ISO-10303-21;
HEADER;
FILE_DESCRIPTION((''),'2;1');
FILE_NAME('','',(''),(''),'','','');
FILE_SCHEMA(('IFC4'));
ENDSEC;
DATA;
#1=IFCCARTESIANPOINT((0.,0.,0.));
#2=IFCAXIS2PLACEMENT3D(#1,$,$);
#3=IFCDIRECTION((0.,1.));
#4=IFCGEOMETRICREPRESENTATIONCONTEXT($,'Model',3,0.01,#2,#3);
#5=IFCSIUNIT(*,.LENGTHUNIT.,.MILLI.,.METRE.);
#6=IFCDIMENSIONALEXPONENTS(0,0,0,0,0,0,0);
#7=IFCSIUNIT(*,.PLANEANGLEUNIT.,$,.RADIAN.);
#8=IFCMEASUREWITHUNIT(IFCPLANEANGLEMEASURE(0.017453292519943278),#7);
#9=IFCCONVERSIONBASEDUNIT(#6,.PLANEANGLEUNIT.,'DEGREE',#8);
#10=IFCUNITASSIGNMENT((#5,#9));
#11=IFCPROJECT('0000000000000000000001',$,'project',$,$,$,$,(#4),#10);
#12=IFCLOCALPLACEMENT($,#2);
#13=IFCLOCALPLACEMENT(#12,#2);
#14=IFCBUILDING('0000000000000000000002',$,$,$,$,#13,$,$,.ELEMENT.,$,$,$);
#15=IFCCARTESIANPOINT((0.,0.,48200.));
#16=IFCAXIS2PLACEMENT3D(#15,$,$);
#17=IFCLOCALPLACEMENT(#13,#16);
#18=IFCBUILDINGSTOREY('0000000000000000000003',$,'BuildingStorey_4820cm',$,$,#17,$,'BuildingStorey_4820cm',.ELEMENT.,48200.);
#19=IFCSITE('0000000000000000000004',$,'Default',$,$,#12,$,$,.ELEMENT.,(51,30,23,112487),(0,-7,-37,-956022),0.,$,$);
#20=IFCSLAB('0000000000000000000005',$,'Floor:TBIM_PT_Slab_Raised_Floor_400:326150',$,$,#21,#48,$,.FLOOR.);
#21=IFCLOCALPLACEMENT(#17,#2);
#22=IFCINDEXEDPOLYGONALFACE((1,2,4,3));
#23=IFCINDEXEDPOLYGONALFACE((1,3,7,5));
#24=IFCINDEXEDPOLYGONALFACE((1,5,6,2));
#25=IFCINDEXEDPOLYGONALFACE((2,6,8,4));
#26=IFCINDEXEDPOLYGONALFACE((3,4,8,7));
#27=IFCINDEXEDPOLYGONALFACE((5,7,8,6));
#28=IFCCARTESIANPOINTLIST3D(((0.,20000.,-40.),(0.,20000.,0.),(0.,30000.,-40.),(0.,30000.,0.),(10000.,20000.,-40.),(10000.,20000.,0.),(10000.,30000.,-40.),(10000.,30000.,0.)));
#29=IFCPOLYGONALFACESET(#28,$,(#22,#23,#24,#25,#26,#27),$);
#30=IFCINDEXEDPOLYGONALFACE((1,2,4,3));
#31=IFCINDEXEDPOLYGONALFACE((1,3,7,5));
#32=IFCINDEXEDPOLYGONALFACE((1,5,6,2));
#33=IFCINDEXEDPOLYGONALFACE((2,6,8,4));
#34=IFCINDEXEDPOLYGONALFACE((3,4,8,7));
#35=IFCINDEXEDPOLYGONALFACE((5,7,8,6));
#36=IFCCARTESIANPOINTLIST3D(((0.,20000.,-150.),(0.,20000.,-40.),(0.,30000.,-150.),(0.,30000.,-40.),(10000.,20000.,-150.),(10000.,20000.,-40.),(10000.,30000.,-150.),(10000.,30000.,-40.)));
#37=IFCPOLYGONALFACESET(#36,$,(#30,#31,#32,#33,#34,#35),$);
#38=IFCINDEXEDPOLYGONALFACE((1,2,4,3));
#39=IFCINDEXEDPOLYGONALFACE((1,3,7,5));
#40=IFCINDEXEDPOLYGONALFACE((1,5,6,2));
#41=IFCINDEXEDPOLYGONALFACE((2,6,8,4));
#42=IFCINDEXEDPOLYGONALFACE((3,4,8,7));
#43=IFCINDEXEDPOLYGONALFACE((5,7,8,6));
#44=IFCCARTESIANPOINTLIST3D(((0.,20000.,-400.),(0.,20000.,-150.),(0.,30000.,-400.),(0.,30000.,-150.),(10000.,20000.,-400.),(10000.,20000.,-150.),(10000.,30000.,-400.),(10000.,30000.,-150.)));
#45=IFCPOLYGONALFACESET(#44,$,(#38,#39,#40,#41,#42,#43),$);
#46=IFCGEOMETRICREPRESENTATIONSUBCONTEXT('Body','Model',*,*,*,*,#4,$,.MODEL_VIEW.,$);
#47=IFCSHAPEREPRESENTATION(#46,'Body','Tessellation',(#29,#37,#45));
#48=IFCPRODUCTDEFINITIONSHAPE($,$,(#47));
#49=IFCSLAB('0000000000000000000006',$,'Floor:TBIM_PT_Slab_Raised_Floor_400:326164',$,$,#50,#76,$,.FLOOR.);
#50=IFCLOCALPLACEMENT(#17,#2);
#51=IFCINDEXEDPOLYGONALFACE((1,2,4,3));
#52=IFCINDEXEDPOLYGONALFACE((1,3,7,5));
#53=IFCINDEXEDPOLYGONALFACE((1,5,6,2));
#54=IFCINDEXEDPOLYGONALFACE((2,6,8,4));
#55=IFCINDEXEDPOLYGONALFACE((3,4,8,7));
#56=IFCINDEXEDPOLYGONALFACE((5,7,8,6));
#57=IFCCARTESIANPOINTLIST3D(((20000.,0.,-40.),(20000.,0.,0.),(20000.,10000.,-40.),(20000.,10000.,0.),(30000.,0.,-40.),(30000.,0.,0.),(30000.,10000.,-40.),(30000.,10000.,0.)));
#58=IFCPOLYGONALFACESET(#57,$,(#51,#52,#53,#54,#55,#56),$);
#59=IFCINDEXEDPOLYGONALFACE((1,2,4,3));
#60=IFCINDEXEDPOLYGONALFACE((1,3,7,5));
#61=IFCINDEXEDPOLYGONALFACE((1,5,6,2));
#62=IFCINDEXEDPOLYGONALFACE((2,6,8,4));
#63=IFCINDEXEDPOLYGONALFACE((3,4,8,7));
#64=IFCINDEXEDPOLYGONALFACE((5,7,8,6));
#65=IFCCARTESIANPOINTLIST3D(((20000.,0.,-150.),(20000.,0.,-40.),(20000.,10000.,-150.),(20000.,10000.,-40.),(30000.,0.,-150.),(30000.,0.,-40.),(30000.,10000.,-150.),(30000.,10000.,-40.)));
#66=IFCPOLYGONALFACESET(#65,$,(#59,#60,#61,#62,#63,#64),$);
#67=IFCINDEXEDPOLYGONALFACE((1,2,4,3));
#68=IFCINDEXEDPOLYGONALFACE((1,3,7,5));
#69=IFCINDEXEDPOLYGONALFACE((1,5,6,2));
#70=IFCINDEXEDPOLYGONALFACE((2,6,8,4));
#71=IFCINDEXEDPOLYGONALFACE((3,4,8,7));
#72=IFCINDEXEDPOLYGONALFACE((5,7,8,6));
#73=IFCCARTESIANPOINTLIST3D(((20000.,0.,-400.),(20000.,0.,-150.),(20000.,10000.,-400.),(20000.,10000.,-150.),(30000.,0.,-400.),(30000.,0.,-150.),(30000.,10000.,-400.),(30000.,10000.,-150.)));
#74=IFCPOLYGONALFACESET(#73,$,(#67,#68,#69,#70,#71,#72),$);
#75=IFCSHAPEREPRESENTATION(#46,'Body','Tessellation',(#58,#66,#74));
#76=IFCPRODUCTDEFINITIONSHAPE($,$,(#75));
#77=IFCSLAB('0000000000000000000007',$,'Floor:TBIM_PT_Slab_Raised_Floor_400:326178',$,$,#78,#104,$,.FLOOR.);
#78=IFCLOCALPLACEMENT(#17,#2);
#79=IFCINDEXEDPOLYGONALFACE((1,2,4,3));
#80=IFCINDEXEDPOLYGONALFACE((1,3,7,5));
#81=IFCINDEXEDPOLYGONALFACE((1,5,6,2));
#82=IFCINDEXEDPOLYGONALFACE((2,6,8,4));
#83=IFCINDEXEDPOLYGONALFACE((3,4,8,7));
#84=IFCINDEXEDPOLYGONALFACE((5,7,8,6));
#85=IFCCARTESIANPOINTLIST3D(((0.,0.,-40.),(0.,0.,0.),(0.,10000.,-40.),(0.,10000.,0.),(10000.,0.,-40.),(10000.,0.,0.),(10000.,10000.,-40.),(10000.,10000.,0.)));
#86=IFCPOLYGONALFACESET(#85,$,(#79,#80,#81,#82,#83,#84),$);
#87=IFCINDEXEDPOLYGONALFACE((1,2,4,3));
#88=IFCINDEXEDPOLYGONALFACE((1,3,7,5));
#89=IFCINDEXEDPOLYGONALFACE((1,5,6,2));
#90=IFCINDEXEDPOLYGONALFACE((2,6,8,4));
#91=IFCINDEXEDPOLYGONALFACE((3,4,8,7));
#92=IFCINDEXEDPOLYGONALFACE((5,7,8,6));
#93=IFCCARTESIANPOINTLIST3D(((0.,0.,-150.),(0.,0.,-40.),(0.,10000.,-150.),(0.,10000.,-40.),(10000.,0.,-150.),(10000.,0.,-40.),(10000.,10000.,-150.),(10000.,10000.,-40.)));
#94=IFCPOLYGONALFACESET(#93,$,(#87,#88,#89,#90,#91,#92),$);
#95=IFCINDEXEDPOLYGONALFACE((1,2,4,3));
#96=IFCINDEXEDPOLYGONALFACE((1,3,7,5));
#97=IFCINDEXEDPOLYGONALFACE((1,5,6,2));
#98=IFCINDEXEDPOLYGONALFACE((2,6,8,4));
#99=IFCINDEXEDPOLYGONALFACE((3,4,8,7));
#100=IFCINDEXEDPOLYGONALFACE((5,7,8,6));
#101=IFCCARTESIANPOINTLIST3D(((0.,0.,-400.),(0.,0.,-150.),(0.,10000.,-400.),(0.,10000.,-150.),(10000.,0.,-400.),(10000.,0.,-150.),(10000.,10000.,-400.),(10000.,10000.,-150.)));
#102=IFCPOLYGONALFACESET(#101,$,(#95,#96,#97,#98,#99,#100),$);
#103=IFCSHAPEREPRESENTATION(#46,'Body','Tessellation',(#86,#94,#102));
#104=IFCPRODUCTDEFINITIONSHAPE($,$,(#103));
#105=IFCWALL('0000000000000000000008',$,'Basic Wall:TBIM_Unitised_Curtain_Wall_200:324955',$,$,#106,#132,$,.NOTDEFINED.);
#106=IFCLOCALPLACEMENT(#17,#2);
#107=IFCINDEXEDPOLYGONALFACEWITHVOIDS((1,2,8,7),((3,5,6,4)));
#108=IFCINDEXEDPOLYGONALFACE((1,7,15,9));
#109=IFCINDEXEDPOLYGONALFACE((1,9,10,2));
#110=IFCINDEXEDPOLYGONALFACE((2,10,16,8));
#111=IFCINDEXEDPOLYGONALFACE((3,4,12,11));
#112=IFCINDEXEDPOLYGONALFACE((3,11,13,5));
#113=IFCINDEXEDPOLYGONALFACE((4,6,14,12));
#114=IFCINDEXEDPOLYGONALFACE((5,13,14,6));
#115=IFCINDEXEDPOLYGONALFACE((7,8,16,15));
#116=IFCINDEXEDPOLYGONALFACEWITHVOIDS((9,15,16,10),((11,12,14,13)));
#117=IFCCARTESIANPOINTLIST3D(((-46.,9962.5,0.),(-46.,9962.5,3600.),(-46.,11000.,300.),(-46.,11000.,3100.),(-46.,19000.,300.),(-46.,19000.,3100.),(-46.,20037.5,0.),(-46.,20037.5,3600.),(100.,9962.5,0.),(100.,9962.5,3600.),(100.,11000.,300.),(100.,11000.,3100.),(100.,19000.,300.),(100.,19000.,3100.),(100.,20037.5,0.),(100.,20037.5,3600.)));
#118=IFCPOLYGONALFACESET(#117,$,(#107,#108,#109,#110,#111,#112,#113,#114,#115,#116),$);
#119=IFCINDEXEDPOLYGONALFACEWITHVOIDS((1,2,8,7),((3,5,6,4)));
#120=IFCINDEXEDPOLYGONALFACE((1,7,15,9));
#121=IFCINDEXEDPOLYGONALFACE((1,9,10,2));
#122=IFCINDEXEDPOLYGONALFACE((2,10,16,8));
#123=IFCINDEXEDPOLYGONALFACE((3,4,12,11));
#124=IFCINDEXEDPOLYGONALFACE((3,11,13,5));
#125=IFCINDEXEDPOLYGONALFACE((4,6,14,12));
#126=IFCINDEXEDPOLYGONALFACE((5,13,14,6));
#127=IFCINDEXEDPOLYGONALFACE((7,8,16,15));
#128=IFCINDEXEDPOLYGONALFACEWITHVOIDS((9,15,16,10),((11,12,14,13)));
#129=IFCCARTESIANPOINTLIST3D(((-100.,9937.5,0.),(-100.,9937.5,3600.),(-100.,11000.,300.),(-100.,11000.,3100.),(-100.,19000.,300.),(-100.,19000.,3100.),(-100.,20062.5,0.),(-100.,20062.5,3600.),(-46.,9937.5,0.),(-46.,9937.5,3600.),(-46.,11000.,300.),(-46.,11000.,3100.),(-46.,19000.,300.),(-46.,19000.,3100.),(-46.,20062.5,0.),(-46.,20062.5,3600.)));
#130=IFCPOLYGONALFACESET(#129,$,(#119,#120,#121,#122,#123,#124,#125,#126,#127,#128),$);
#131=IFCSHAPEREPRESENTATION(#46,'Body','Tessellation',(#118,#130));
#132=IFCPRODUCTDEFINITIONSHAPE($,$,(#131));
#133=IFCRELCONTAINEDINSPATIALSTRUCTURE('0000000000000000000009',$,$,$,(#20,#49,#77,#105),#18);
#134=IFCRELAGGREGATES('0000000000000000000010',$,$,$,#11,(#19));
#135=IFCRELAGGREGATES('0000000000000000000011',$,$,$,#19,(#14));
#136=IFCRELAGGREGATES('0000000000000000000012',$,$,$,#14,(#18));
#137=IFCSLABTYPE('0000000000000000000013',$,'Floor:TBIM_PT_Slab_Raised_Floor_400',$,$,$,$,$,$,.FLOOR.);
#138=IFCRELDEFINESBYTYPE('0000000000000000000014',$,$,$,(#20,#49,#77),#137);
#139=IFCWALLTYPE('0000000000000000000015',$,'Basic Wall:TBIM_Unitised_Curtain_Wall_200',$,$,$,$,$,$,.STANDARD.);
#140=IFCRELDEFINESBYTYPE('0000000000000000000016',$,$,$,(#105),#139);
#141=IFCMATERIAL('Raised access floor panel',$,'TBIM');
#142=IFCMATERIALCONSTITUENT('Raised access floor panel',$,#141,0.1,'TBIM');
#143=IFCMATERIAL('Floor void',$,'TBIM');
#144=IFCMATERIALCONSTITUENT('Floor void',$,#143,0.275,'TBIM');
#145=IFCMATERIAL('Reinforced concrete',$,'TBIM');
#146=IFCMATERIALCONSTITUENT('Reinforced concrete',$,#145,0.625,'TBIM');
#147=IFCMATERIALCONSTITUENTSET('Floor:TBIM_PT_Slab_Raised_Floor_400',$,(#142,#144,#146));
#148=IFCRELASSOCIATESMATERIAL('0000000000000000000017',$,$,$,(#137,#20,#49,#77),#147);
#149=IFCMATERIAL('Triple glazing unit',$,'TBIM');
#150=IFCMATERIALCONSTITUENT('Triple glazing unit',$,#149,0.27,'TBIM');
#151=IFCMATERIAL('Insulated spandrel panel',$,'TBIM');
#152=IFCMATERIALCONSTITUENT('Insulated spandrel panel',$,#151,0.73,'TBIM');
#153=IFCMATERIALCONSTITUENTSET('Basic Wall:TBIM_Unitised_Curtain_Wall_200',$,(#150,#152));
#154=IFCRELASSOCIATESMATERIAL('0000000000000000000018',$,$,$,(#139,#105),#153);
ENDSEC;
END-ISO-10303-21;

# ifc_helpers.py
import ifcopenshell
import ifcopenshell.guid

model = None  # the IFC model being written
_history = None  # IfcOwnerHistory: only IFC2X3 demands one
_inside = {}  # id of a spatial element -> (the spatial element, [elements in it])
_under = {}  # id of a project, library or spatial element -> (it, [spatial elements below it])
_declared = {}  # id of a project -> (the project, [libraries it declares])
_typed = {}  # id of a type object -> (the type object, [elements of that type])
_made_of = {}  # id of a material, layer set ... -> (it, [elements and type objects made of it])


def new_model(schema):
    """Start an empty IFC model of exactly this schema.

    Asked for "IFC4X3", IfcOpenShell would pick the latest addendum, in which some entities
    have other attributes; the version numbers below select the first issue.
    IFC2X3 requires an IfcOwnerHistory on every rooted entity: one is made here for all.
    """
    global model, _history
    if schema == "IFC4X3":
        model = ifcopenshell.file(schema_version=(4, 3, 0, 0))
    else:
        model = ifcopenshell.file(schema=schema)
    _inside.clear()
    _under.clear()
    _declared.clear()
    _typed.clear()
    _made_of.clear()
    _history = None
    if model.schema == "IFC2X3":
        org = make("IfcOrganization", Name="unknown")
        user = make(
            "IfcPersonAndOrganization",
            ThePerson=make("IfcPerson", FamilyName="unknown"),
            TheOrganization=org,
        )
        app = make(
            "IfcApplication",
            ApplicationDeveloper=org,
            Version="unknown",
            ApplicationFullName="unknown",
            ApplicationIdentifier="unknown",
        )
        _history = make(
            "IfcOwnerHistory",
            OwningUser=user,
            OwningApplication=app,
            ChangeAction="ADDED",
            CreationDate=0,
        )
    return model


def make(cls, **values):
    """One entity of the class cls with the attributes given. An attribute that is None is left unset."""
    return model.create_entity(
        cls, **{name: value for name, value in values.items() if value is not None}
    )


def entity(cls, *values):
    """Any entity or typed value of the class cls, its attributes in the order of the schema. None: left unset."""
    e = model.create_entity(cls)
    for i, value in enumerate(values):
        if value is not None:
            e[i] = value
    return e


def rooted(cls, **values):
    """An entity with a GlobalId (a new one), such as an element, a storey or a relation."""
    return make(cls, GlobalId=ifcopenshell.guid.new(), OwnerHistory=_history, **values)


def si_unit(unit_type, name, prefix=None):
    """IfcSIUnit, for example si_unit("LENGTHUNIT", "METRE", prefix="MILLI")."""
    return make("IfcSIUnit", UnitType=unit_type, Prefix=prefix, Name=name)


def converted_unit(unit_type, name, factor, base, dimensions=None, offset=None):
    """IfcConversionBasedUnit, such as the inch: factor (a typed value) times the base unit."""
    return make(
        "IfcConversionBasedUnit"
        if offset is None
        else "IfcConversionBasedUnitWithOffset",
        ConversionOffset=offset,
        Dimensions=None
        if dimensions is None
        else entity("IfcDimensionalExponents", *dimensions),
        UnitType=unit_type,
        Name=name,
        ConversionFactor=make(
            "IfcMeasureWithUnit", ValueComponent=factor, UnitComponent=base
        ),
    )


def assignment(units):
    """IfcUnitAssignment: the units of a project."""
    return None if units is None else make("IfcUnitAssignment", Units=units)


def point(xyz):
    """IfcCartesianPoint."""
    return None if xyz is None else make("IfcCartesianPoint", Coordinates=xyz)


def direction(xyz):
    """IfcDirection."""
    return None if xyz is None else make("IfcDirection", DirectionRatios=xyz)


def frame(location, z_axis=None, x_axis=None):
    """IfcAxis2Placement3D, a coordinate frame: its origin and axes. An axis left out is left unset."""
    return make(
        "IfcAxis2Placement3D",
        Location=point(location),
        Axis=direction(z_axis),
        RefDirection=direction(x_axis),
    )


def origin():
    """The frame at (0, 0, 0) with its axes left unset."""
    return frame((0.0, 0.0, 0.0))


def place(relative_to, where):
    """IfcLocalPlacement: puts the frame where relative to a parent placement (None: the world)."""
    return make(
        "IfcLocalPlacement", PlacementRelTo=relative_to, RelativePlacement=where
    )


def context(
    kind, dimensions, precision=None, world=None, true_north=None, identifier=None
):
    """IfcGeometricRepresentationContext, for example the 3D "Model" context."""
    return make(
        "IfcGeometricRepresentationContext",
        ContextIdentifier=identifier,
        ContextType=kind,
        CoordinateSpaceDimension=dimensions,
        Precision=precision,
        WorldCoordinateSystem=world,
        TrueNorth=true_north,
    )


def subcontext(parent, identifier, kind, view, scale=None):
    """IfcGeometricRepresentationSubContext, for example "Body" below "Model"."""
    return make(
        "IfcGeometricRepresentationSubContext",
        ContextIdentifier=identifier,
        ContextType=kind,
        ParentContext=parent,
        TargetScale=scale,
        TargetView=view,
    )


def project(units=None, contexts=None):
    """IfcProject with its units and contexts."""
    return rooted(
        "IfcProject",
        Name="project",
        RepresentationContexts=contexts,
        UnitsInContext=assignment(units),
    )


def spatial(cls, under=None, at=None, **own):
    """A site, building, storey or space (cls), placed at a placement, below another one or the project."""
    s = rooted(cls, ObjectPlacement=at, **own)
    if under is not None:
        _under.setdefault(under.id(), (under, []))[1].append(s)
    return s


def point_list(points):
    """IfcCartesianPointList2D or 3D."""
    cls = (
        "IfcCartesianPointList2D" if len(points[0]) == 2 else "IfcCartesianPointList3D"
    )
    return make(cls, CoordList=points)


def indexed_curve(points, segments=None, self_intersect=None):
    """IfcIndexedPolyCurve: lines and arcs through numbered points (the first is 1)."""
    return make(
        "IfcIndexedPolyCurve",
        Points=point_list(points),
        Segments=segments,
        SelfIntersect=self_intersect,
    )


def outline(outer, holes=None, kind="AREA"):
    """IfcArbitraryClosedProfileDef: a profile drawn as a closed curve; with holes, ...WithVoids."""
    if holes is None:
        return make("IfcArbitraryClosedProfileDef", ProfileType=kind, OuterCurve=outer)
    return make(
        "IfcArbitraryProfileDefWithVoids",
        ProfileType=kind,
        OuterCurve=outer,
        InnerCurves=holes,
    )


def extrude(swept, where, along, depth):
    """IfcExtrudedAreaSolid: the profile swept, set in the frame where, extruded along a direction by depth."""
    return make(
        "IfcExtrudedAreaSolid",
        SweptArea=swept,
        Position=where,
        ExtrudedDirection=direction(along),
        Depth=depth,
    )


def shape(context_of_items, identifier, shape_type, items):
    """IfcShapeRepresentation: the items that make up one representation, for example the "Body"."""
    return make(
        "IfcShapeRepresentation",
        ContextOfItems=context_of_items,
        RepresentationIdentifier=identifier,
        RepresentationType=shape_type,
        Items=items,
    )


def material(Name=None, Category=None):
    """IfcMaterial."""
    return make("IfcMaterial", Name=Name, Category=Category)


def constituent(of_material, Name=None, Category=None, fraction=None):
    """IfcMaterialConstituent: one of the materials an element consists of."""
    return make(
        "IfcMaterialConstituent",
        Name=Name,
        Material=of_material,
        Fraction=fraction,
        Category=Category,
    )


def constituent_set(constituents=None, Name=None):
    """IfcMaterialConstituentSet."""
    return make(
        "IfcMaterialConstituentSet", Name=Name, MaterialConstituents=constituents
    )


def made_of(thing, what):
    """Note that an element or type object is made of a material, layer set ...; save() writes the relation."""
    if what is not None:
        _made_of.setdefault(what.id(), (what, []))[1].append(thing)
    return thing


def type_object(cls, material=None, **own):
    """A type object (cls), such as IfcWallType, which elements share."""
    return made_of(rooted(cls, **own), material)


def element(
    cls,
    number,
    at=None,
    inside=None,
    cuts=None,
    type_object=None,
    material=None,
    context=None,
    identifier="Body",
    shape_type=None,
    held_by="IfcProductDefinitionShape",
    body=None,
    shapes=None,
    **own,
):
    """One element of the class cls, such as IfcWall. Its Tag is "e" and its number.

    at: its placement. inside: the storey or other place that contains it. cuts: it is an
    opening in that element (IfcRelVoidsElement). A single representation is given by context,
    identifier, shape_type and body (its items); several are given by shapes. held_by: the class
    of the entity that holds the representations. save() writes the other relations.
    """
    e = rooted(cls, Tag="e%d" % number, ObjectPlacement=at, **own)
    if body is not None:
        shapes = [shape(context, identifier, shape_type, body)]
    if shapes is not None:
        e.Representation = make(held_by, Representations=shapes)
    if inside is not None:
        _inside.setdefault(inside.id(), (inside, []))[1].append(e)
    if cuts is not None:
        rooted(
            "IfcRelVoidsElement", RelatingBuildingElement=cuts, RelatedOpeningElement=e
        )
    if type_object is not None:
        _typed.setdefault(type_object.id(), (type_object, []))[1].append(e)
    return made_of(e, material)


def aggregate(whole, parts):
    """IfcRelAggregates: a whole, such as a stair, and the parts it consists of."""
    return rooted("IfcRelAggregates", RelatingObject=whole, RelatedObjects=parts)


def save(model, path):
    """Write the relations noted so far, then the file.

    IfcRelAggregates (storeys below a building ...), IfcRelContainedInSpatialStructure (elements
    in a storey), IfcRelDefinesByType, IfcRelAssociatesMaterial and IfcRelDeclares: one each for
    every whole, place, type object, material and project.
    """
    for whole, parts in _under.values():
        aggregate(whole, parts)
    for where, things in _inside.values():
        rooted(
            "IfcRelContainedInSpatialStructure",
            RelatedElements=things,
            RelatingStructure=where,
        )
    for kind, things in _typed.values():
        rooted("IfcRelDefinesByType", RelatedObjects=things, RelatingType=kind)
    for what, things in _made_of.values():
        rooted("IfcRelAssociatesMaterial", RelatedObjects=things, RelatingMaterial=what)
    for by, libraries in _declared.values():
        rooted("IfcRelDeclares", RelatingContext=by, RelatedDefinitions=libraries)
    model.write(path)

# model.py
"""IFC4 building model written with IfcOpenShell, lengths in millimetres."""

from ifc_helpers import new_model, entity, si_unit, converted_unit, direction, frame, origin, place, context, subcontext, project, spatial, indexed_curve, outline, extrude, material, constituent, constituent_set, type_object, element, save


model = new_model("IFC4")

# Units and contexts
model_context = context("Model", 3, precision=0.01, world=origin(), true_north=direction((0.0, 1.0)))
body_context = subcontext(model_context, "Body", "Model", "MODEL_VIEW")
ifc_project = project(units=[si_unit("LENGTHUNIT", "METRE", prefix="MILLI"), converted_unit("PLANEANGLEUNIT", "DEGREE", entity("IfcPlaneAngleMeasure", 0.017453292519943278), si_unit("PLANEANGLEUNIT", "RADIAN"), dimensions=[0, 0, 0, 0, 0, 0, 0])], contexts=[model_context])

# Site, building, storey
site_placement = place(None, origin())
site = spatial("IfcSite", under=ifc_project, at=site_placement, Name="Default", CompositionType="ELEMENT", RefLatitude=(51, 30, 23, 112487), RefLongitude=(0, -7, -37, -956022), RefElevation=0.0)
building_placement = place(site_placement, origin())
building = spatial("IfcBuilding", under=site, at=building_placement, CompositionType="ELEMENT")
storey_placement = place(building_placement, frame((0.0, 0.0, 48200.0)))
storey = spatial("IfcBuildingStorey", under=building, at=storey_placement, Name="BuildingStorey_4820cm", LongName="BuildingStorey_4820cm", CompositionType="ELEMENT", Elevation=48200.0)

# Slabs
ifc_material_1 = material(Name="Raised access floor panel", Category="TBIM")
ifc_constituent_1 = constituent(ifc_material_1, Name="Raised access floor panel", Category="TBIM", fraction=0.1)
ifc_material_2 = material(Name="Floor void", Category="TBIM")
ifc_constituent_2 = constituent(ifc_material_2, Name="Floor void", Category="TBIM", fraction=0.275)
ifc_material_3 = material(Name="Reinforced concrete", Category="TBIM")
ifc_constituent_3 = constituent(ifc_material_3, Name="Reinforced concrete", Category="TBIM", fraction=0.625)
ifc_constituent_set_1 = constituent_set(constituents=[ifc_constituent_1, ifc_constituent_2, ifc_constituent_3], Name="Floor:TBIM_PT_Slab_Raised_Floor_400")
slab_type = type_object("IfcSlabType", Name="Floor:TBIM_PT_Slab_Raised_Floor_400", PredefinedType="FLOOR", material=ifc_constituent_set_1)
slab_1_placement = place(storey_placement, origin())
element("IfcSlab", 1, at=slab_1_placement, inside=storey, type_object=slab_type, material=ifc_constituent_set_1, Name="Floor:TBIM_PT_Slab_Raised_Floor_400:326150", PredefinedType="FLOOR", context=body_context, shape_type="SweptSolid", body=[
    extrude(outline(indexed_curve([(-5000.0, -5000.0), (5000.0, -5000.0), (5000.0, 5000.0), (-5000.0, 5000.0), (-5000.0, -5000.0)], self_intersect=False)), frame((5000.0, 25000.0, -40.0), z_axis=(0.0, 0.0, 1.0), x_axis=(-1.0, 0.0, 0.0)), (0.0, 0.0, 1.0), 40.0),
    extrude(outline(indexed_curve([(-5000.0, -5000.0), (5000.0, -5000.0), (5000.0, 5000.0), (-5000.0, 5000.0), (-5000.0, -5000.0)], self_intersect=False)), frame((5000.0, 25000.0, -150.0), z_axis=(0.0, 0.0, 1.0), x_axis=(-1.0, 0.0, 0.0)), (0.0, 0.0, 1.0), 110.0),
    extrude(outline(indexed_curve([(-5000.0, -5000.0), (5000.0, -5000.0), (5000.0, 5000.0), (-5000.0, 5000.0), (-5000.0, -5000.0)], self_intersect=False)), frame((5000.0, 25000.0, -400.0), z_axis=(0.0, 0.0, 1.0), x_axis=(-1.0, 0.0, 0.0)), (0.0, 0.0, 1.0), 250.0),
])
slab_2_placement = place(storey_placement, origin())
element("IfcSlab", 2, at=slab_2_placement, inside=storey, type_object=slab_type, material=ifc_constituent_set_1, Name="Floor:TBIM_PT_Slab_Raised_Floor_400:326164", PredefinedType="FLOOR", context=body_context, shape_type="SweptSolid", body=[
    extrude(outline(indexed_curve([(-5000.0, -5000.0), (5000.0, -5000.0), (5000.0, 5000.0), (-5000.0, 5000.0), (-5000.0, -5000.0)], self_intersect=False)), frame((25000.0, 5000.0, -40.0), z_axis=(0.0, 0.0, 1.0), x_axis=(-1.0, 0.0, 0.0)), (0.0, 0.0, 1.0), 40.0),
    extrude(outline(indexed_curve([(-5000.0, -5000.0), (5000.0, -5000.0), (5000.0, 5000.0), (-5000.0, 5000.0), (-5000.0, -5000.0)], self_intersect=False)), frame((25000.0, 5000.0, -150.0), z_axis=(0.0, 0.0, 1.0), x_axis=(-1.0, 0.0, 0.0)), (0.0, 0.0, 1.0), 110.0),
    extrude(outline(indexed_curve([(-5000.0, -5000.0), (5000.0, -5000.0), (5000.0, 5000.0), (-5000.0, 5000.0), (-5000.0, -5000.0)], self_intersect=False)), frame((25000.0, 5000.0, -400.0), z_axis=(0.0, 0.0, 1.0), x_axis=(-1.0, 0.0, 0.0)), (0.0, 0.0, 1.0), 250.0),
])
slab_3_placement = place(storey_placement, origin())
element("IfcSlab", 3, at=slab_3_placement, inside=storey, type_object=slab_type, material=ifc_constituent_set_1, Name="Floor:TBIM_PT_Slab_Raised_Floor_400:326178", PredefinedType="FLOOR", context=body_context, shape_type="SweptSolid", body=[
    extrude(outline(indexed_curve([(-5000.0, -5000.0), (5000.0, -5000.0), (5000.0, 5000.0), (-5000.0, 5000.0), (-5000.0, -5000.0)], self_intersect=False)), frame((5000.0, 5000.0, -40.0), z_axis=(0.0, 0.0, 1.0), x_axis=(-1.0, 0.0, 0.0)), (0.0, 0.0, 1.0), 40.0),
    extrude(outline(indexed_curve([(-5000.0, -5000.0), (5000.0, -5000.0), (5000.0, 5000.0), (-5000.0, 5000.0), (-5000.0, -5000.0)], self_intersect=False)), frame((5000.0, 5000.0, -150.0), z_axis=(0.0, 0.0, 1.0), x_axis=(-1.0, 0.0, 0.0)), (0.0, 0.0, 1.0), 110.0),
    extrude(outline(indexed_curve([(-5000.0, -5000.0), (5000.0, -5000.0), (5000.0, 5000.0), (-5000.0, 5000.0), (-5000.0, -5000.0)], self_intersect=False)), frame((5000.0, 5000.0, -400.0), z_axis=(0.0, 0.0, 1.0), x_axis=(-1.0, 0.0, 0.0)), (0.0, 0.0, 1.0), 250.0),
])

# Wall, opening
ifc_material_4 = material(Name="Triple glazing unit", Category="TBIM")
ifc_constituent_4 = constituent(ifc_material_4, Name="Triple glazing unit", Category="TBIM", fraction=0.27)
ifc_material_5 = material(Name="Insulated spandrel panel", Category="TBIM")
ifc_constituent_5 = constituent(ifc_material_5, Name="Insulated spandrel panel", Category="TBIM", fraction=0.73)
ifc_constituent_set_2 = constituent_set(constituents=[ifc_constituent_4, ifc_constituent_5], Name="Basic Wall:TBIM_Unitised_Curtain_Wall_200")
wall_type = type_object("IfcWallType", Name="Basic Wall:TBIM_Unitised_Curtain_Wall_200", PredefinedType="STANDARD", material=ifc_constituent_set_2)
wall_1_placement = place(storey_placement, frame((0.0, 9937.5, 0.0), z_axis=(0.0, 0.0, 1.0), x_axis=(0.0, 1.0, 0.0)))
wall_1 = element("IfcWall", 4, at=wall_1_placement, inside=storey, type_object=wall_type, material=ifc_constituent_set_2, Name="Basic Wall:TBIM_Unitised_Curtain_Wall_200:324955", PredefinedType="NOTDEFINED", context=body_context, shape_type="SweptSolid", body=[
    extrude(outline(indexed_curve([(-1800.0, -5037.5), (1800.0, -5037.5), (1800.0, 5037.5), (-1800.0, 5037.5), (-1800.0, -5037.5)], self_intersect=False), holes=[indexed_curve([(1300.0, 4000.0), (1300.0, -4000.0), (-1500.0, -4000.0), (-1500.0, 4000.0), (1300.0, 4000.0)], self_intersect=False)]), frame((5062.5, 46.0, 1800.0), z_axis=(0.0, -1.0, 0.0), x_axis=(0.0, 0.0, 1.0)), (0.0, 0.0, 1.0), 146.0),
    extrude(outline(indexed_curve([(-5062.5, -1800.0), (5062.5, -1800.0), (5062.5, 1800.0), (-5062.5, 1800.0), (-5062.5, -1800.0)], self_intersect=False), holes=[indexed_curve([(-4000.0, 1300.0), (4000.0, 1300.0), (4000.0, -1500.0), (-4000.0, -1500.0), (-4000.0, 1300.0)], self_intersect=False)]), frame((5062.5, 100.0, 1800.0), z_axis=(0.0, -1.0, 0.0), x_axis=(1.0, 0.0, 0.0)), (0.0, 0.0, 1.0), 54.0),
])
opening_1_placement = place(wall_1_placement, frame((1062.5, -100.0, 300.0)))
element("IfcOpeningElement", 5, at=opening_1_placement, cuts=wall_1, PredefinedType="OPENING", context=body_context, shape_type="SweptSolid", body=[
    extrude(outline(indexed_curve([(2800.0, 0.0), (2800.0, 8000.0), (0.0, 8000.0), (0.0, 0.0), (2800.0, 0.0)], self_intersect=False)), frame((0.0, 0.0, 0.0), z_axis=(0.0, 1.0, 0.0), x_axis=(0.0, 0.0, 1.0)), (0.0, 0.0, 1.0), 200.0),
])

save(model, "model.ifc")
